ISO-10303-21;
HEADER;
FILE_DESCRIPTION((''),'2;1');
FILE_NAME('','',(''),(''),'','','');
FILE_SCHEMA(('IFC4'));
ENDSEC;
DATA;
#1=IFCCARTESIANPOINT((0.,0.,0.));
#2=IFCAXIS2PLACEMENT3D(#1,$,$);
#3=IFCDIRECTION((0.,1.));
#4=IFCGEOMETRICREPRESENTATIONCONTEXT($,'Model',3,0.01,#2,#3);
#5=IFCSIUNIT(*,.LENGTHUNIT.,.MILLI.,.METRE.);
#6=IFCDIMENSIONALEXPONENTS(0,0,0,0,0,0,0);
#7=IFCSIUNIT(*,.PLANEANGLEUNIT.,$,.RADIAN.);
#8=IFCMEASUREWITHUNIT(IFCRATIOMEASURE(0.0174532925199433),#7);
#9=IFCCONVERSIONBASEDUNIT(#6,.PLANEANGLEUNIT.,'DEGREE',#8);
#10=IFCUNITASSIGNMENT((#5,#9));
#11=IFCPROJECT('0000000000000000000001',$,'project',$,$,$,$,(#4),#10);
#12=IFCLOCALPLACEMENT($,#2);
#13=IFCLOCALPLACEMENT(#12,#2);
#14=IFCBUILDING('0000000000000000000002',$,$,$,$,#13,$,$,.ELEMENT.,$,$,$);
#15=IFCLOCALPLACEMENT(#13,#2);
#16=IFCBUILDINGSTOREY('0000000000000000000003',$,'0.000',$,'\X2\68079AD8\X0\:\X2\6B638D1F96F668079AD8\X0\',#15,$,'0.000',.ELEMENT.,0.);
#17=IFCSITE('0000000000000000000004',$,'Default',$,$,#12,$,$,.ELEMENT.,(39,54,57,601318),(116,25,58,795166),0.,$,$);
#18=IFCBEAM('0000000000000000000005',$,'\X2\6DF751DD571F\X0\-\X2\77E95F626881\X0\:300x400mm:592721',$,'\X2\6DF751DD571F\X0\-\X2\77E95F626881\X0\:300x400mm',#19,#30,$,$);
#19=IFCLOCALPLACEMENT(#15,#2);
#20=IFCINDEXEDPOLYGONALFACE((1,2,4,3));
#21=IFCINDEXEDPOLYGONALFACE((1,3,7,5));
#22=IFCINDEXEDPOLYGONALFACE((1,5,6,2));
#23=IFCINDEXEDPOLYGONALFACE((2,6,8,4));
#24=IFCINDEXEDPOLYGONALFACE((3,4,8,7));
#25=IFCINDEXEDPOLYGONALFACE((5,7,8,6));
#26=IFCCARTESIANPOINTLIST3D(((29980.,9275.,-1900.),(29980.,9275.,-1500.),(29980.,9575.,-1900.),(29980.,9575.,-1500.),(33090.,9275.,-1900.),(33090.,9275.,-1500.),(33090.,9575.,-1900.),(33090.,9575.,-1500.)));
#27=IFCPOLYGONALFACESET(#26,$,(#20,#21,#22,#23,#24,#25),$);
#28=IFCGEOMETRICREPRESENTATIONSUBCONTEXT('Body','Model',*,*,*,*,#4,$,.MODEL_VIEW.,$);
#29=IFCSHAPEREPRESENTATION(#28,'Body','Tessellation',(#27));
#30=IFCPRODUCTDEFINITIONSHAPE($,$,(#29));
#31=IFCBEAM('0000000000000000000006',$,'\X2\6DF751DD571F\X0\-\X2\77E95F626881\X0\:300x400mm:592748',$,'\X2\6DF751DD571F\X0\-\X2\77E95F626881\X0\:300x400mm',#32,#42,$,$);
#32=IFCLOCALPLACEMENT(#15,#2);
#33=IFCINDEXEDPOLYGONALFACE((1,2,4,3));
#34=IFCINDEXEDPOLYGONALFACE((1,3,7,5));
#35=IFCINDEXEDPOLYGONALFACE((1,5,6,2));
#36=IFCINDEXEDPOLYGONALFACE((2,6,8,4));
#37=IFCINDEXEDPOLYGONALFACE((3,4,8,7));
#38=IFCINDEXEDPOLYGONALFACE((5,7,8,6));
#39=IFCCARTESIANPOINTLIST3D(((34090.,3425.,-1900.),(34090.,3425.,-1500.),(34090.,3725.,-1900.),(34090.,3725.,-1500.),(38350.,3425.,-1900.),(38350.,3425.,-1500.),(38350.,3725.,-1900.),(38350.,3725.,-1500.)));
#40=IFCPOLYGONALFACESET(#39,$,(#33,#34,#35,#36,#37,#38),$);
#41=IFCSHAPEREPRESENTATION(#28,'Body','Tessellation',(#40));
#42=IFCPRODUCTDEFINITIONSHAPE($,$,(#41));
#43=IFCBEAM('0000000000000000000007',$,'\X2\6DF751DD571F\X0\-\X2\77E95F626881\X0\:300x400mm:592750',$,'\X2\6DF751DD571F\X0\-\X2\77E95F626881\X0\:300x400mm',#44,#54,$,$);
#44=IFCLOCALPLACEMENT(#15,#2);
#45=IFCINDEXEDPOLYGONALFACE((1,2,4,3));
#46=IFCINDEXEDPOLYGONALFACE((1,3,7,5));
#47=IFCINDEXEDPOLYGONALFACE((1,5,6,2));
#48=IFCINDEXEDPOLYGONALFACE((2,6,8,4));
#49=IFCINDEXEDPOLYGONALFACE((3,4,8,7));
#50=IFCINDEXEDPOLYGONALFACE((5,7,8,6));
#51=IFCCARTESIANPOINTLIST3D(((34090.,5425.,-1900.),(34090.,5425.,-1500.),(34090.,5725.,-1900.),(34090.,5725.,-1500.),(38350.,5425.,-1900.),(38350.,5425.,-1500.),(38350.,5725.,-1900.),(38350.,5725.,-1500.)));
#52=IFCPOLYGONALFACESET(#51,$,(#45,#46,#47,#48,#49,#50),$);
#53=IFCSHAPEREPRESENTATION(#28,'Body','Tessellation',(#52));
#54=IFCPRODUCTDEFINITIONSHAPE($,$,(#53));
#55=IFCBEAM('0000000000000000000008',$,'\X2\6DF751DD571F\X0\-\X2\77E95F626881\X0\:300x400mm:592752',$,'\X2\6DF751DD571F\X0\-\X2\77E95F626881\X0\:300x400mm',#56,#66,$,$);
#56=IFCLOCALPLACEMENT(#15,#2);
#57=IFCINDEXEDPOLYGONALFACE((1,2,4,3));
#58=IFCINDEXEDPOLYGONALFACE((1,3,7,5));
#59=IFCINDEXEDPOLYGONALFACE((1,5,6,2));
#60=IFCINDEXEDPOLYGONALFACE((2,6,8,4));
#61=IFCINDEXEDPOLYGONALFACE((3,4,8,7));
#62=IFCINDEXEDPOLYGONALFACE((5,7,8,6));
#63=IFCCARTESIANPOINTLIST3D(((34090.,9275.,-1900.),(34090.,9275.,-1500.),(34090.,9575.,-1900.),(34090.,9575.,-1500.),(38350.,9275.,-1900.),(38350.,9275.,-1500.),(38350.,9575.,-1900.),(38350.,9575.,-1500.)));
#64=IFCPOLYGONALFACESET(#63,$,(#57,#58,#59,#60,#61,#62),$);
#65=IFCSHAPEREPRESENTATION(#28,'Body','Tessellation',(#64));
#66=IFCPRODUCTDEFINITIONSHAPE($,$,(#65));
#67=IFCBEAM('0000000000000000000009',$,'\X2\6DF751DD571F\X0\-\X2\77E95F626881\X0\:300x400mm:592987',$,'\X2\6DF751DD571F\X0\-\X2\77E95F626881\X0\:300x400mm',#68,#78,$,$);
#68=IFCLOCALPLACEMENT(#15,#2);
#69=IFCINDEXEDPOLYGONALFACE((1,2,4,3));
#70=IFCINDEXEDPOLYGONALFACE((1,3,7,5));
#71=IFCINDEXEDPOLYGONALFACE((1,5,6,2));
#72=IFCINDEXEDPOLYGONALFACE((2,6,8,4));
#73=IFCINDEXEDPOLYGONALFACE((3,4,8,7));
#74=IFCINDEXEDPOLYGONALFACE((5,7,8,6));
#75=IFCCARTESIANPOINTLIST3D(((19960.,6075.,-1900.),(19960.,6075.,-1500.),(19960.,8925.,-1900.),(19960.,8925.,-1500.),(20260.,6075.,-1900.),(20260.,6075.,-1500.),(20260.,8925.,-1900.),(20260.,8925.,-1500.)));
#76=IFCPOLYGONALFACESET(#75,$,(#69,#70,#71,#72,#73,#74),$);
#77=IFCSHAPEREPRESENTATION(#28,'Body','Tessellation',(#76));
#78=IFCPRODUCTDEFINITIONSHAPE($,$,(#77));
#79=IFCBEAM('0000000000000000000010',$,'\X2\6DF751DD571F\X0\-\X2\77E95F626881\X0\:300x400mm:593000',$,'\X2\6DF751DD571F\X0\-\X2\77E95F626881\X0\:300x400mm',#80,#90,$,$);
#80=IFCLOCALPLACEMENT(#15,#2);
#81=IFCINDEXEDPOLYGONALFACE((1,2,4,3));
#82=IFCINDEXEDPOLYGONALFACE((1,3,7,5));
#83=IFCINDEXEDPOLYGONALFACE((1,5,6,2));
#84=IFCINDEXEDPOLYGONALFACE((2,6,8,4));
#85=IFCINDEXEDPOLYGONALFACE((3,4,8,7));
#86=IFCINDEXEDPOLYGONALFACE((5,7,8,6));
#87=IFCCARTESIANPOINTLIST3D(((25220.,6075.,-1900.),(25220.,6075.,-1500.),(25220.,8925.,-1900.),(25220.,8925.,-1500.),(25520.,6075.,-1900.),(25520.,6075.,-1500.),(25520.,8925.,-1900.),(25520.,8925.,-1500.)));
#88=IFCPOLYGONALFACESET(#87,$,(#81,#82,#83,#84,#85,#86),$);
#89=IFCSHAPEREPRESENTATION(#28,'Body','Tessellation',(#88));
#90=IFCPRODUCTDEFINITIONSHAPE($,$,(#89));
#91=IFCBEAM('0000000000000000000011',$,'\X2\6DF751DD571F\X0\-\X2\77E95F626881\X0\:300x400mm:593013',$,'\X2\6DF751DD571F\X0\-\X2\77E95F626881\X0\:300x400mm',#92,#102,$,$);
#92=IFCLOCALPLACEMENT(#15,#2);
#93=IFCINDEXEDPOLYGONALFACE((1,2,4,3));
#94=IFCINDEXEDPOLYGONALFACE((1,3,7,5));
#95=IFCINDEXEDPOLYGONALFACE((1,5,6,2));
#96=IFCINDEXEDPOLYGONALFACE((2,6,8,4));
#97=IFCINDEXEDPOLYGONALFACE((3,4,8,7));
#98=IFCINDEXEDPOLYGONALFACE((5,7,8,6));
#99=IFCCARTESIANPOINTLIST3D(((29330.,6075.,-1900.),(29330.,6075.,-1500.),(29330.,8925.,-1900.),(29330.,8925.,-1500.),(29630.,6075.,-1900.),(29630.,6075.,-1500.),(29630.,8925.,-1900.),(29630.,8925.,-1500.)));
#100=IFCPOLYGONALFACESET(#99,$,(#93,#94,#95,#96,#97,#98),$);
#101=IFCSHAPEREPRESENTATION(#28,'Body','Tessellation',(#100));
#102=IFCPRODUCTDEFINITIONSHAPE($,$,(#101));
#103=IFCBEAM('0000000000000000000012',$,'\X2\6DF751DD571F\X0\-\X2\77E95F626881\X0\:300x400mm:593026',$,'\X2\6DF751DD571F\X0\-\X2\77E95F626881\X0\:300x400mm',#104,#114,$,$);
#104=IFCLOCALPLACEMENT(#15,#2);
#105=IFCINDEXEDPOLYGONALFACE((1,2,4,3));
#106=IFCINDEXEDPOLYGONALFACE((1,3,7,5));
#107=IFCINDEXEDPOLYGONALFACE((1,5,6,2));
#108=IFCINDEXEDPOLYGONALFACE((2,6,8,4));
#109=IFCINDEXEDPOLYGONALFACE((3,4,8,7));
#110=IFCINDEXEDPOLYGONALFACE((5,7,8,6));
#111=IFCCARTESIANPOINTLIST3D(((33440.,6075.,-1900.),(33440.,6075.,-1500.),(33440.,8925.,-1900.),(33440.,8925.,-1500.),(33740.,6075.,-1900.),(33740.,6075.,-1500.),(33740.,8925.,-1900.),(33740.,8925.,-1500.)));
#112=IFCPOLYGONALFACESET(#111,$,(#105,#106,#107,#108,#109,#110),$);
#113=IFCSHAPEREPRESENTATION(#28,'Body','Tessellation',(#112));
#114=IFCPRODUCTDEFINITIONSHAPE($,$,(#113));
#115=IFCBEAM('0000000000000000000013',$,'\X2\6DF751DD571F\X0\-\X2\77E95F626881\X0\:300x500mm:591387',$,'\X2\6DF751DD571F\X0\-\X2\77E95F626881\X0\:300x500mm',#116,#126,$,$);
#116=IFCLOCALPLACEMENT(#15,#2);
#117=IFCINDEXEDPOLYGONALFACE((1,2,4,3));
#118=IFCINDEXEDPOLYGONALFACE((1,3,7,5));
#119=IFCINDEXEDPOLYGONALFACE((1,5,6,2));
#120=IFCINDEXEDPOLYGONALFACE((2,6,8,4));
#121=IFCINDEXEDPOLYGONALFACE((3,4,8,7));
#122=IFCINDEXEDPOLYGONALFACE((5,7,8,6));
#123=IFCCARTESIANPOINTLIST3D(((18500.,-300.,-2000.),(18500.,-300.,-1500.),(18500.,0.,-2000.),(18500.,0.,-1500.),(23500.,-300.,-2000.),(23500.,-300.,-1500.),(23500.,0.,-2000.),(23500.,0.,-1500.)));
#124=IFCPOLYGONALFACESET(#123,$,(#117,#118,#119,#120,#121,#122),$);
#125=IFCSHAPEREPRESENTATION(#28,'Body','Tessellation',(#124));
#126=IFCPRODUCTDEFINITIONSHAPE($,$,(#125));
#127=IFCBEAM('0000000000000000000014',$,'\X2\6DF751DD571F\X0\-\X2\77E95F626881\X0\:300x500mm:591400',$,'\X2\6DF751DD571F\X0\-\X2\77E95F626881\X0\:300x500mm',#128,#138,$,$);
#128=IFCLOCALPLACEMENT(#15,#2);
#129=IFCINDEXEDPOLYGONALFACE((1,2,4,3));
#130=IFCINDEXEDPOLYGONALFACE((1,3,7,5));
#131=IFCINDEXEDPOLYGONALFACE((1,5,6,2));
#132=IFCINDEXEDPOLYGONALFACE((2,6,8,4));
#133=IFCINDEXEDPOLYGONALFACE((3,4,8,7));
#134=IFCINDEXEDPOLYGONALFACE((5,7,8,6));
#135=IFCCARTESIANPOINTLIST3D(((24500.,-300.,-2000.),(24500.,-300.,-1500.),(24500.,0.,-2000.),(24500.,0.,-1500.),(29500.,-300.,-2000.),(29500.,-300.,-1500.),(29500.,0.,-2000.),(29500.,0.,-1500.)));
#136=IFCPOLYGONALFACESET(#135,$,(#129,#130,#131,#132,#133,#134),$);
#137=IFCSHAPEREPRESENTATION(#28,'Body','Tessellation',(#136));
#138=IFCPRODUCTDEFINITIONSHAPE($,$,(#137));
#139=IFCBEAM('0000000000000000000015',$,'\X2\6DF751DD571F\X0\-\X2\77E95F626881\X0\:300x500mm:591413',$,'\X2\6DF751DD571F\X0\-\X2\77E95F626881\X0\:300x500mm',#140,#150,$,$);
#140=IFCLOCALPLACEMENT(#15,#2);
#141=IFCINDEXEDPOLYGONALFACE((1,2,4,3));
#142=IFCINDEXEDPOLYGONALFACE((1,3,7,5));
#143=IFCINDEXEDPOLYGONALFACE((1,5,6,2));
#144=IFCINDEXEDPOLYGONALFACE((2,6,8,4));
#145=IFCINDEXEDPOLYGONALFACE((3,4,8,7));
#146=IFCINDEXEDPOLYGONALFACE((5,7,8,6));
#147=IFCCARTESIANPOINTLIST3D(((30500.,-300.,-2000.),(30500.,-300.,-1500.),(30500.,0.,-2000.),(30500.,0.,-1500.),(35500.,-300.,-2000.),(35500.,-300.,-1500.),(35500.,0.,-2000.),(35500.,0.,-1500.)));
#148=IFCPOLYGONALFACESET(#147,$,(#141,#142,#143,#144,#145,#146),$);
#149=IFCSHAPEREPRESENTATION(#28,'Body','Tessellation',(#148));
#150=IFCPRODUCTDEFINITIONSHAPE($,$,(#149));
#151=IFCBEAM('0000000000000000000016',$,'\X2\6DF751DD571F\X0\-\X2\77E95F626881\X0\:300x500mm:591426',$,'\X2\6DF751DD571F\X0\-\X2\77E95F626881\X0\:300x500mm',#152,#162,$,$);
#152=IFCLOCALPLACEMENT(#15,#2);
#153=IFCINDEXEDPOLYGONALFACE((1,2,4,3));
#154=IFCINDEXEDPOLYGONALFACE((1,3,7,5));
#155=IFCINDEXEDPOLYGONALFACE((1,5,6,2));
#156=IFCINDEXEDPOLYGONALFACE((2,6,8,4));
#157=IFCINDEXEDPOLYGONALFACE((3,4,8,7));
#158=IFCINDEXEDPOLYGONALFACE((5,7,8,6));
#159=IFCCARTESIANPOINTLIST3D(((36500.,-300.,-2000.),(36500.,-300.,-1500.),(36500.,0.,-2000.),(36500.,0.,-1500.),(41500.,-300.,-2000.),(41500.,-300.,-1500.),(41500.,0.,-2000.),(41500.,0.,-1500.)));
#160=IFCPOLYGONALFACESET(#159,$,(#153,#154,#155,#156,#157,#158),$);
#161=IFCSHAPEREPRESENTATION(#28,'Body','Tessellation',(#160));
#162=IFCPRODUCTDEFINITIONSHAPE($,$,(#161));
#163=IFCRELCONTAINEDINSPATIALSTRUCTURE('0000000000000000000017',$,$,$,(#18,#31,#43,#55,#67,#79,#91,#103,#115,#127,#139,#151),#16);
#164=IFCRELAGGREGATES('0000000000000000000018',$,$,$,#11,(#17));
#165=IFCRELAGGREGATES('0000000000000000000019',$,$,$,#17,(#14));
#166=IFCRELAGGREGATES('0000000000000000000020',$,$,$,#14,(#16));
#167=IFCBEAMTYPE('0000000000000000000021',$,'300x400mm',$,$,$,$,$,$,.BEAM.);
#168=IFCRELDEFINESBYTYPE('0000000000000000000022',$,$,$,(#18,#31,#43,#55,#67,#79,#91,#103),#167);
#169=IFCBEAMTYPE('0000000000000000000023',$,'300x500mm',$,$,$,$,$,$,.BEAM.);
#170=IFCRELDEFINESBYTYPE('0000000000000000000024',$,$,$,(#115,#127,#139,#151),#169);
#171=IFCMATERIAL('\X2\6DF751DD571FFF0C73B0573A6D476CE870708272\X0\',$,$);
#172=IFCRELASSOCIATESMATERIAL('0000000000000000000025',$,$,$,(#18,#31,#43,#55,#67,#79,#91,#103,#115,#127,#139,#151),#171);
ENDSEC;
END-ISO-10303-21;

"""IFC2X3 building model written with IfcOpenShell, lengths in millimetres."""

from ifc_helpers import new_model, entity, si_unit, converted_unit, direction, frame, frame_2d, origin, place, context, subcontext, project, spatial, rectangle, extrude, material, type_object, element, save


model = new_model("IFC2X3")

# Units and contexts
model_context = context("Model", 3, precision=0.01, world=origin(), true_north=direction((0.0, 1.0)))
body_context = subcontext(model_context, "Body", "Model", "MODEL_VIEW")
ifc_project = project(units=[si_unit("LENGTHUNIT", "METRE", prefix="MILLI"), converted_unit("PLANEANGLEUNIT", "DEGREE", entity("IfcRatioMeasure", 0.0174532925199433), si_unit("PLANEANGLEUNIT", "RADIAN"), dimensions=[0, 0, 0, 0, 0, 0, 0])], contexts=[model_context])

# Site, building, storey
site_placement = place(None, origin())
site = spatial("IfcSite", under=ifc_project, at=site_placement, Name="Default", CompositionType="ELEMENT", RefLatitude=(39, 54, 57, 601318), RefLongitude=(116, 25, 58, 795166), RefElevation=0.0)
building_placement = place(site_placement, origin())
building = spatial("IfcBuilding", under=site, at=building_placement, CompositionType="ELEMENT")
storey_placement = place(building_placement, origin())
storey = spatial("IfcBuildingStorey", under=building, at=storey_placement, Name="0.000", ObjectType="标高:正负零标高", LongName="0.000", CompositionType="ELEMENT", Elevation=0.0)

# Shared definitions
ifc_material = material(Name="混凝土，现场浇注灰色")

# Beams
beam_type_1 = type_object("IfcBeamType", Name="300x400mm", PredefinedType="BEAM")
beam_1_placement = place(storey_placement, frame((33090.0, 9425.0, -1500.0), z_axis=(0.0, 0.0, 1.0), x_axis=(-1.0, 0.0, 0.0)))
element("IfcBeam", 1, at=beam_1_placement, inside=storey, type_object=beam_type_1, material=ifc_material, Name="混凝土-矩形梁:300x400mm:592721", ObjectType="混凝土-矩形梁:300x400mm", context=body_context, shape_type="SweptSolid", body=[
    extrude(rectangle(XDim=400.0, YDim=300.0, at=frame_2d((0.0, 0.0), x_axis=(1.0, 0.0))), frame((0.0, 0.0, -200.0), z_axis=(1.0, 0.0, 0.0), x_axis=(0.0, 0.0, -1.0)), (0.0, 0.0, 1.0), 3110.0),
])
beam_2_placement = place(storey_placement, frame((38350.0, 3575.0, -1500.0), z_axis=(0.0, 0.0, 1.0), x_axis=(-1.0, 0.0, 0.0)))
element("IfcBeam", 2, at=beam_2_placement, inside=storey, type_object=beam_type_1, material=ifc_material, Name="混凝土-矩形梁:300x400mm:592748", ObjectType="混凝土-矩形梁:300x400mm", context=body_context, shape_type="SweptSolid", body=[
    extrude(rectangle(XDim=400.0, YDim=300.0, at=frame_2d((0.0, 0.0), x_axis=(1.0, 0.0))), frame((0.0, 0.0, -200.0), z_axis=(1.0, 0.0, 0.0), x_axis=(0.0, 0.0, -1.0)), (0.0, 0.0, 1.0), 4260.0),
])
beam_3_placement = place(storey_placement, frame((38350.0, 5575.0, -1500.0), z_axis=(0.0, 0.0, 1.0), x_axis=(-1.0, 0.0, 0.0)))
element("IfcBeam", 3, at=beam_3_placement, inside=storey, type_object=beam_type_1, material=ifc_material, Name="混凝土-矩形梁:300x400mm:592750", ObjectType="混凝土-矩形梁:300x400mm", context=body_context, shape_type="SweptSolid", body=[
    extrude(rectangle(XDim=400.0, YDim=300.0, at=frame_2d((0.0, 0.0), x_axis=(1.0, 0.0))), frame((0.0, 0.0, -200.0), z_axis=(1.0, 0.0, 0.0), x_axis=(0.0, 0.0, -1.0)), (0.0, 0.0, 1.0), 4260.0),
])
beam_4_placement = place(storey_placement, frame((38350.0, 9425.0, -1500.0), z_axis=(0.0, 0.0, 1.0), x_axis=(-1.0, 0.0, 0.0)))
element("IfcBeam", 4, at=beam_4_placement, inside=storey, type_object=beam_type_1, material=ifc_material, Name="混凝土-矩形梁:300x400mm:592752", ObjectType="混凝土-矩形梁:300x400mm", context=body_context, shape_type="SweptSolid", body=[
    extrude(rectangle(XDim=400.0, YDim=300.0, at=frame_2d((0.0, 0.0), x_axis=(1.0, 0.0))), frame((0.0, 0.0, -200.0), z_axis=(1.0, 0.0, 0.0), x_axis=(0.0, 0.0, -1.0)), (0.0, 0.0, 1.0), 4260.0),
])
for number, where, z_axis, x_axis, name in (
    (5, (20110.0, 8925.0, -1500.0), (0.0, 0.0, 1.0), (0.0, -1.0, 0.0), "混凝土-矩形梁:300x400mm:592987"),
    (6, (25370.0, 8925.0, -1500.0), (0.0, 0.0, 1.0), (0.0, -1.0, 0.0), "混凝土-矩形梁:300x400mm:593000"),
    (7, (29480.0, 8925.0, -1500.0), (0.0, 0.0, 1.0), (0.0, -1.0, 0.0), "混凝土-矩形梁:300x400mm:593013"),
    (8, (33590.0, 8925.0, -1500.0), (0.0, 0.0, 1.0), (0.0, -1.0, 0.0), "混凝土-矩形梁:300x400mm:593026"),
):
    element("IfcBeam", number, at=place(storey_placement, frame(where, z_axis=z_axis, x_axis=x_axis)), inside=storey, type_object=beam_type_1, material=ifc_material, Name=name, ObjectType="混凝土-矩形梁:300x400mm", context=body_context, shape_type="SweptSolid", body=[
        extrude(rectangle(XDim=400.0, YDim=300.0, at=frame_2d((0.0, 0.0), x_axis=(1.0, 0.0))), frame((0.0, 0.0, -200.0), z_axis=(1.0, 0.0, 0.0), x_axis=(0.0, 0.0, -1.0)), (0.0, 0.0, 1.0), 2850.0),
    ])
beam_type_2 = type_object("IfcBeamType", Name="300x500mm", PredefinedType="BEAM")
for number, where, name in (
    (9, (18500.0, -150.0, -1500.0), "混凝土-矩形梁:300x500mm:591387"),
    (10, (24500.0, -150.0, -1500.0), "混凝土-矩形梁:300x500mm:591400"),
    (11, (30500.0, -150.0, -1500.0), "混凝土-矩形梁:300x500mm:591413"),
    (12, (36500.0, -150.0, -1500.0), "混凝土-矩形梁:300x500mm:591426"),
):
    element("IfcBeam", number, at=place(storey_placement, frame(where)), inside=storey, type_object=beam_type_2, material=ifc_material, Name=name, ObjectType="混凝土-矩形梁:300x500mm", context=body_context, shape_type="SweptSolid", body=[
        extrude(rectangle(XDim=500.0, YDim=300.0, at=frame_2d((0.0, 0.0), x_axis=(1.0, 0.0))), frame((0.0, 0.0, -250.0), z_axis=(1.0, 0.0, 0.0), x_axis=(0.0, 0.0, -1.0)), (0.0, 0.0, 1.0), 5000.0),
    ])

save(model, "model.ifc")
